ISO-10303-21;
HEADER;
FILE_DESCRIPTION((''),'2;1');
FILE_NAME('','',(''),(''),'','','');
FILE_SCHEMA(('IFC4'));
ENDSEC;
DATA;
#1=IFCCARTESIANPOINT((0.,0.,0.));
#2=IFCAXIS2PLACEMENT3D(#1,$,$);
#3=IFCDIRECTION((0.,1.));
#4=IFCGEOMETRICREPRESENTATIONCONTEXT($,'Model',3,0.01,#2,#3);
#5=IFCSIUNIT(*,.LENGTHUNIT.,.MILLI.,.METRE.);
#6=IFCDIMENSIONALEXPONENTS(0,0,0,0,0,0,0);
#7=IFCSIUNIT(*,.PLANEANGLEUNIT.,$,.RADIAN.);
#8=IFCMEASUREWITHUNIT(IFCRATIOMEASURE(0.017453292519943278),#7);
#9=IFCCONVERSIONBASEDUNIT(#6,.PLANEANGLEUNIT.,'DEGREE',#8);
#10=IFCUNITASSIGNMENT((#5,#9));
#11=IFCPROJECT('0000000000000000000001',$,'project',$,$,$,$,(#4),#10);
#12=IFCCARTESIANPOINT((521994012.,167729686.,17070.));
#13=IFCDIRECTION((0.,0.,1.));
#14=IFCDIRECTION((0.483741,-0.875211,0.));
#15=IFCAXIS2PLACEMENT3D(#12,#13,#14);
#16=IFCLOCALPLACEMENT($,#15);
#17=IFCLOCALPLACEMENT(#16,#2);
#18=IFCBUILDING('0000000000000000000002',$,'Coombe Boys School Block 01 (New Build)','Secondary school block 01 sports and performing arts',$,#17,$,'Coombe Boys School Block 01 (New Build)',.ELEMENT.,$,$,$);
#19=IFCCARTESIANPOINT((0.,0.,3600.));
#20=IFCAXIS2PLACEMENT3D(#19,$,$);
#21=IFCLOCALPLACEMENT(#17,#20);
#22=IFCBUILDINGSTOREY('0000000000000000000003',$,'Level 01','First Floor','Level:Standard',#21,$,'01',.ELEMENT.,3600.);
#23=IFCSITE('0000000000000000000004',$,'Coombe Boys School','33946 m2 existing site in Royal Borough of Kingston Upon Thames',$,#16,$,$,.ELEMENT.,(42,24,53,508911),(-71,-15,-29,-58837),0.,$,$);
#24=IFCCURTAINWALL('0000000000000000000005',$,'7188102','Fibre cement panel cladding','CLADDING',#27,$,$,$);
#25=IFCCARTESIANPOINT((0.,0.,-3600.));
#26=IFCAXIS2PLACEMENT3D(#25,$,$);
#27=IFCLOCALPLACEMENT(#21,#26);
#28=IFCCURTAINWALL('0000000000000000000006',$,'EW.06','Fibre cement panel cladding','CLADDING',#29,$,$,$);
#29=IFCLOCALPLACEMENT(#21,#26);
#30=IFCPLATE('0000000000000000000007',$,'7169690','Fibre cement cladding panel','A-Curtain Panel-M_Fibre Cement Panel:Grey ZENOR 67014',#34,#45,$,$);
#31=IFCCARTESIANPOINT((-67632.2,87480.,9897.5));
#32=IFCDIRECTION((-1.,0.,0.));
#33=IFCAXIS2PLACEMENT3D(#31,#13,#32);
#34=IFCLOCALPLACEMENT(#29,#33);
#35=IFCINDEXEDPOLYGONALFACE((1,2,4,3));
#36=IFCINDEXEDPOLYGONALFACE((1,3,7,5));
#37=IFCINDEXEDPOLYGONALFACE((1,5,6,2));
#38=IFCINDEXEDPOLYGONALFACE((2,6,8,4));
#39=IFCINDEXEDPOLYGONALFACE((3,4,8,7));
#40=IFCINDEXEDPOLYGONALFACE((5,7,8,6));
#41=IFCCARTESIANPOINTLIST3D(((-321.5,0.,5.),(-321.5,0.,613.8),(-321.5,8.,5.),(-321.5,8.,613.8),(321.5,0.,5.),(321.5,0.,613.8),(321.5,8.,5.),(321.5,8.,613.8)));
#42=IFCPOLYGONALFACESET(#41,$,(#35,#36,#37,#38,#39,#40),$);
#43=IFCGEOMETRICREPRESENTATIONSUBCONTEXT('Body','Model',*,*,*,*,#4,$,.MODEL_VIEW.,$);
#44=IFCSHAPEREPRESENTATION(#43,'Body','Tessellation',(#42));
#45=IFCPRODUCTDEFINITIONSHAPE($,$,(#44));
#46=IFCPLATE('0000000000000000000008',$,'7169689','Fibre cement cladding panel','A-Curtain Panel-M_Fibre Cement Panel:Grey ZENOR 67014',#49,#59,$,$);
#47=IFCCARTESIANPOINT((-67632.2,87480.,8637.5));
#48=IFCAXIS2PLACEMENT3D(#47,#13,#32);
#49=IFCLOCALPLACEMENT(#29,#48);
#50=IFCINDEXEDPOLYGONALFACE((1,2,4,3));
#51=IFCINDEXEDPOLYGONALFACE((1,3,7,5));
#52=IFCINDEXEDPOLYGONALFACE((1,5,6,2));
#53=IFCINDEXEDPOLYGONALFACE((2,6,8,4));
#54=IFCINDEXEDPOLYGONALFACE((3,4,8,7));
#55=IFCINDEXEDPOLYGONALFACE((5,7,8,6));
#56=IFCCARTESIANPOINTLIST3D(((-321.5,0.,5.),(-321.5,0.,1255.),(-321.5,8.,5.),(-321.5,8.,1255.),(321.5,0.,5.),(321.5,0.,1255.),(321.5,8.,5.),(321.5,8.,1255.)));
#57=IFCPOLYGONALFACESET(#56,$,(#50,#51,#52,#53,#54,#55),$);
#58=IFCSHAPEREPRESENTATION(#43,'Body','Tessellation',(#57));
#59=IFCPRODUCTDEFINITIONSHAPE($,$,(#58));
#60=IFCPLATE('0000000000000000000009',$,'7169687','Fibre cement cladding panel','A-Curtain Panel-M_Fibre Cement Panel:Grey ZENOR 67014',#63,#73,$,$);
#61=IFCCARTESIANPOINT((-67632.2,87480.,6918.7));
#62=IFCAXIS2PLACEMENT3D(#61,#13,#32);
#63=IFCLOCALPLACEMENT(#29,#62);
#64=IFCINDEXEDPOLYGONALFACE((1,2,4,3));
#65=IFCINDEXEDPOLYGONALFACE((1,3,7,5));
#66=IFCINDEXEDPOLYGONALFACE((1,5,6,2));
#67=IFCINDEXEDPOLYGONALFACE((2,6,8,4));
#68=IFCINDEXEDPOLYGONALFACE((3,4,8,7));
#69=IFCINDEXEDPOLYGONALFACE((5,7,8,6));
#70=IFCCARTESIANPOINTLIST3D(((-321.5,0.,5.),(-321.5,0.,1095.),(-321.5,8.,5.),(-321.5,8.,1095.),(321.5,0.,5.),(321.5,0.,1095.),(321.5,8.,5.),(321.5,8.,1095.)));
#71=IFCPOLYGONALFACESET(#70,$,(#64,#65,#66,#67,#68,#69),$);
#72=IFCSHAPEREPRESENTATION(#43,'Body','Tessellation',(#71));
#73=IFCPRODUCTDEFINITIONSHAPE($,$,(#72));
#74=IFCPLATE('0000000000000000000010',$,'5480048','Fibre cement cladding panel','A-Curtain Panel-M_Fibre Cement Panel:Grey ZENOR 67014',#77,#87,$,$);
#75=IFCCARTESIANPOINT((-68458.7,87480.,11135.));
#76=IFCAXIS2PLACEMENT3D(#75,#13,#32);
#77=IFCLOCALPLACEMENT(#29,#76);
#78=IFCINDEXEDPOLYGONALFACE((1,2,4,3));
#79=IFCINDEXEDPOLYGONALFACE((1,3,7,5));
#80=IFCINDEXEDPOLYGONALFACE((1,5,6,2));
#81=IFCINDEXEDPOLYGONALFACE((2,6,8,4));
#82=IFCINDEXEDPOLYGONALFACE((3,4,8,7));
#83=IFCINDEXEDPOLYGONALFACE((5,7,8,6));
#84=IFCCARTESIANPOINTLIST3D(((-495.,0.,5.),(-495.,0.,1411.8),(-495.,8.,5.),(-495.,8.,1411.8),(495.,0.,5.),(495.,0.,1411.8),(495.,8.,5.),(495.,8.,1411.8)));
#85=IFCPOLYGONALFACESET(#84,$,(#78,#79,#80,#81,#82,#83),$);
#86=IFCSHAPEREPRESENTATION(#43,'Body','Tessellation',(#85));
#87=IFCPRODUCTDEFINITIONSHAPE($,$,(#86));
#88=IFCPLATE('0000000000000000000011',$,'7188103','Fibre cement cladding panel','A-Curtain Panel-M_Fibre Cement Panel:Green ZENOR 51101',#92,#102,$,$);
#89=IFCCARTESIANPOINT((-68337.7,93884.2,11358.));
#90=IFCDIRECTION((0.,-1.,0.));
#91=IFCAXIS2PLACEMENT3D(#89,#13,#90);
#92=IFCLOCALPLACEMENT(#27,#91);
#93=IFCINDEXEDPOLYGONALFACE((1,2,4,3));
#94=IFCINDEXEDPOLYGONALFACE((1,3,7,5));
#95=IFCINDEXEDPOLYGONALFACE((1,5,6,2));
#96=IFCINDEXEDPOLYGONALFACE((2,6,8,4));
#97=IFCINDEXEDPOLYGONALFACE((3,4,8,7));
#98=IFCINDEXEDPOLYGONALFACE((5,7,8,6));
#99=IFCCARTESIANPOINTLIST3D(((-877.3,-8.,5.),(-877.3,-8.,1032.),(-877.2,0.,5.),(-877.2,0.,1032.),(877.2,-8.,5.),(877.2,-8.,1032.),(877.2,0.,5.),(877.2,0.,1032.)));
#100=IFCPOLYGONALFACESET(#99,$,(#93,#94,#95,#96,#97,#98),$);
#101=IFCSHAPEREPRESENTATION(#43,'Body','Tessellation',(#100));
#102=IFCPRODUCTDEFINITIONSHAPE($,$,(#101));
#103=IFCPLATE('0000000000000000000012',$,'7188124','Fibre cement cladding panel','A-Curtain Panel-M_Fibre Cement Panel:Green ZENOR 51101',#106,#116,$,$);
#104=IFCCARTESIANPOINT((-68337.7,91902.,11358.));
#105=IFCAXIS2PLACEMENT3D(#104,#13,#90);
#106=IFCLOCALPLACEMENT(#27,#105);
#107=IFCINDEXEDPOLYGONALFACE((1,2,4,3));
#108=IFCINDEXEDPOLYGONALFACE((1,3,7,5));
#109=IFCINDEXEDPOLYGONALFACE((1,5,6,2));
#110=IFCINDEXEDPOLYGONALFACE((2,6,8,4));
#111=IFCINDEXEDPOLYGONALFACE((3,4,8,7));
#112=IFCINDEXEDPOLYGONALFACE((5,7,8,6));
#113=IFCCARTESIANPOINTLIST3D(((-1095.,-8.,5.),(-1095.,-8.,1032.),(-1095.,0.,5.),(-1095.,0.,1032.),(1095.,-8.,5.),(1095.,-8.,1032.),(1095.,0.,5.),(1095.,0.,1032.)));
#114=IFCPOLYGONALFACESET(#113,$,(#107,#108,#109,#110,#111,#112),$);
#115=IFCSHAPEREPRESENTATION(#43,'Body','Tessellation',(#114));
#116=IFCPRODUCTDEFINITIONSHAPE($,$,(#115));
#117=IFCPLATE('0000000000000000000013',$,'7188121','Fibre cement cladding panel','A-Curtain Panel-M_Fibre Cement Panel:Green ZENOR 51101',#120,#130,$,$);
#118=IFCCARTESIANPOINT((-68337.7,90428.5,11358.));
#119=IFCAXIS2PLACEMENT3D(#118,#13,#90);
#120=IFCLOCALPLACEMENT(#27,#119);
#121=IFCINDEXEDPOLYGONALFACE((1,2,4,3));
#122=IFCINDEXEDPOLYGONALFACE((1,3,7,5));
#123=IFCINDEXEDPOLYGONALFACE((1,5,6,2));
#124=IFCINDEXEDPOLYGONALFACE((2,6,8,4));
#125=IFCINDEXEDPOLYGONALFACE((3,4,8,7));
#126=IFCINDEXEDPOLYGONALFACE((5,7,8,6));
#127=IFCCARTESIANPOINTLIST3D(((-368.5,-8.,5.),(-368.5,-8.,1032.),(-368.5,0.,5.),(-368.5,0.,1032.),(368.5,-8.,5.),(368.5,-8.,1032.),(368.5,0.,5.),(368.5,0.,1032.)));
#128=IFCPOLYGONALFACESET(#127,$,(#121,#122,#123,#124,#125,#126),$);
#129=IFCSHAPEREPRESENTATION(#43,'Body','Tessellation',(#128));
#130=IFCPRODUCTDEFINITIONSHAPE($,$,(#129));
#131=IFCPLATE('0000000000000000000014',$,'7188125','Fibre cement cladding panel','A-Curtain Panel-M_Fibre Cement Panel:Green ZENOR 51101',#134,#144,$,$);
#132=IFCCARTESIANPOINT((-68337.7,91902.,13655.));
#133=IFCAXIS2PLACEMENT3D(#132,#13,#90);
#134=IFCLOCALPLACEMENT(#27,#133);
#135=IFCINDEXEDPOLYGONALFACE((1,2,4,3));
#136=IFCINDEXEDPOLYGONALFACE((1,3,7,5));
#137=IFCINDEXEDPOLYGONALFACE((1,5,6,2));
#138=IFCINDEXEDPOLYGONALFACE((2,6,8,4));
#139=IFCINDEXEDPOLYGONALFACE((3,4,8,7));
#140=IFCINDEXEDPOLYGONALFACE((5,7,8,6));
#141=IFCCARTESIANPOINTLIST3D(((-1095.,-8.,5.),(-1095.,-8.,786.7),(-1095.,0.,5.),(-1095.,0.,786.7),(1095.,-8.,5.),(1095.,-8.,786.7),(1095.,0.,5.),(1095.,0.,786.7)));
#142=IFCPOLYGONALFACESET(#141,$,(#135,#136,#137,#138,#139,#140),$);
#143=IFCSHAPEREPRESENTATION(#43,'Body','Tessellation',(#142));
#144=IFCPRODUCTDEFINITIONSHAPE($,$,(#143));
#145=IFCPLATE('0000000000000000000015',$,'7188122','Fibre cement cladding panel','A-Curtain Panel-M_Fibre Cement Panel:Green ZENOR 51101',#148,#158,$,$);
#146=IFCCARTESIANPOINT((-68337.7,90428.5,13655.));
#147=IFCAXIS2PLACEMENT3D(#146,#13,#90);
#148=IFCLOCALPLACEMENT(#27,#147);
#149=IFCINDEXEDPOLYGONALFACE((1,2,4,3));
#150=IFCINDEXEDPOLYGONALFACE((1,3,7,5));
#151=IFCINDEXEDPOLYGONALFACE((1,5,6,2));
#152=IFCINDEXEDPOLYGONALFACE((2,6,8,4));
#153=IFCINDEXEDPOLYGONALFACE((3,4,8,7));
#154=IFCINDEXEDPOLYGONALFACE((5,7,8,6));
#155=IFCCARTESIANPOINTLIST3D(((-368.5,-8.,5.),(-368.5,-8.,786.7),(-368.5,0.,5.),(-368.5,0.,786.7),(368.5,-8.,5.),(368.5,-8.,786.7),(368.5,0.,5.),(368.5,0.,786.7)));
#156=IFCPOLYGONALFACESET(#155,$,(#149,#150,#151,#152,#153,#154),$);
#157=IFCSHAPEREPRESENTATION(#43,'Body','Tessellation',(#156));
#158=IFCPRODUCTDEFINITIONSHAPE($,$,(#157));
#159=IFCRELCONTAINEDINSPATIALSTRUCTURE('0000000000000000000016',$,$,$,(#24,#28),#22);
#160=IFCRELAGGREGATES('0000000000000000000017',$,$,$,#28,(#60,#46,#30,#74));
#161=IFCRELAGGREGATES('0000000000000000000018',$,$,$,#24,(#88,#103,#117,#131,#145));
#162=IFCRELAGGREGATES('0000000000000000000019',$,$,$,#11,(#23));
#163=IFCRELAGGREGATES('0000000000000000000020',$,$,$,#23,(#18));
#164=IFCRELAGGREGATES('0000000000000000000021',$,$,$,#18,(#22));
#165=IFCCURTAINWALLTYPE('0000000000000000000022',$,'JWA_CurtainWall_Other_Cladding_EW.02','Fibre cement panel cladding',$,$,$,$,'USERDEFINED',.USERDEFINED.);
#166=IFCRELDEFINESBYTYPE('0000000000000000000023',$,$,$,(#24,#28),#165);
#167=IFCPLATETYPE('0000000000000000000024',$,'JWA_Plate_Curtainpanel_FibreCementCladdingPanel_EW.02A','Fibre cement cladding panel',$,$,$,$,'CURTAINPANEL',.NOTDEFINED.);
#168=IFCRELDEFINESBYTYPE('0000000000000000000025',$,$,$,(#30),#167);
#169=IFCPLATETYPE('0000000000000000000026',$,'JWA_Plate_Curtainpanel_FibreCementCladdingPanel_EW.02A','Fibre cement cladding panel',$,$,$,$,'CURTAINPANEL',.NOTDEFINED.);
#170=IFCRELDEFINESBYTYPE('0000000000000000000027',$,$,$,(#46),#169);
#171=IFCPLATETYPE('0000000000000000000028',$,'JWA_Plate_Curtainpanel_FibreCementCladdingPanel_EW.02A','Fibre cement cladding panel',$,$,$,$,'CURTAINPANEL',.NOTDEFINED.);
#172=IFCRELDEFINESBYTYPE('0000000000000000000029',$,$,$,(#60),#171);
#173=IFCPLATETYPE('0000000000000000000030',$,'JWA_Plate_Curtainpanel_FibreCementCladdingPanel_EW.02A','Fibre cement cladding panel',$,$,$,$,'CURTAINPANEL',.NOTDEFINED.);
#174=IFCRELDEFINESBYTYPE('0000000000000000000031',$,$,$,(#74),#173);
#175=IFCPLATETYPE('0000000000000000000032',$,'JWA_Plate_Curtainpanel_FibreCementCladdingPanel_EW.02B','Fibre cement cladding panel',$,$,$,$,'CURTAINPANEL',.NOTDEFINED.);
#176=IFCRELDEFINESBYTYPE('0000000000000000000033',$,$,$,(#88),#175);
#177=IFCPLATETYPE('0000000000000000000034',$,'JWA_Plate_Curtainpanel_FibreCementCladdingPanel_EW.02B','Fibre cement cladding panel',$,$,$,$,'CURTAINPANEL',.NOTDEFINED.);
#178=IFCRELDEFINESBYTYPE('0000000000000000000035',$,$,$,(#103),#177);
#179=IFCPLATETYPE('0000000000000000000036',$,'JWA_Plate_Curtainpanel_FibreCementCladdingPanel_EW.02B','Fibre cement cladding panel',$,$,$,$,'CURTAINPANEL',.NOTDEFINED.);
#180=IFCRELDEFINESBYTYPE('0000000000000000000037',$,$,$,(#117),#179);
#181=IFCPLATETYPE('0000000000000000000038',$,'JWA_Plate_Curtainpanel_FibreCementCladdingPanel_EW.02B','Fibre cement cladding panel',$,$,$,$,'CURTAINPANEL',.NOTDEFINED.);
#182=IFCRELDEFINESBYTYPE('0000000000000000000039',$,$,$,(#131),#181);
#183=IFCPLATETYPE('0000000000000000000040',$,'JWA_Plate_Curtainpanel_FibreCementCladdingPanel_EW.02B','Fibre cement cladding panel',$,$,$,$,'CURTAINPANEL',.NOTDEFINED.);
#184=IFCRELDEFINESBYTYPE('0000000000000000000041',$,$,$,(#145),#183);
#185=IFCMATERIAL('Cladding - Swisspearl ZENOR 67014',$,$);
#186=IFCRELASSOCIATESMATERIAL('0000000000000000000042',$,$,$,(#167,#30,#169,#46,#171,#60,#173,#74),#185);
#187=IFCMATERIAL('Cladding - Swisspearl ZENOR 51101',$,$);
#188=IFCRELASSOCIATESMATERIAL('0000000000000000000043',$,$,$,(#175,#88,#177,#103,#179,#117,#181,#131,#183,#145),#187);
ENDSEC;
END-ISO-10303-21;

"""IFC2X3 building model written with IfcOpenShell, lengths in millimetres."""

from ifc_helpers import new_model, entity, si_unit, converted_unit, direction, frame, origin, origin_2d_with_axis, place, context, subcontext, project, spatial, rectangle, extrude, source, transform, mapped, material, type_object, type_shapes, element, aggregate, save


model = new_model("IFC2X3")

# Units and contexts
model_context = context("Model", 3, precision=0.01, world=origin(), true_north=direction((0.0, 1.0)))
body_context = subcontext(model_context, "Body", "Model", "MODEL_VIEW")
ifc_project = project(units=[si_unit("LENGTHUNIT", "METRE", prefix="MILLI"), converted_unit("PLANEANGLEUNIT", "DEGREE", entity("IfcRatioMeasure", 0.017453292519943278), si_unit("PLANEANGLEUNIT", "RADIAN"), dimensions=[0, 0, 0, 0, 0, 0, 0])], contexts=[model_context])

# Site, building, storey
site_placement = place(None, frame((521994012.0, 167729686.0, 17070.0), z_axis=(0.0, 0.0, 1.0), x_axis=(0.483741, -0.875211, 0.0)))
site = spatial("IfcSite", under=ifc_project, at=site_placement, Name="Coombe Boys School", Description="33946 m2 existing site in Royal Borough of Kingston Upon Thames", CompositionType="ELEMENT", RefLatitude=(42, 24, 53, 508911), RefLongitude=(-71, -15, -29, -58837), RefElevation=0.0)
building_placement = place(site_placement, origin())
building = spatial("IfcBuilding", under=site, at=building_placement, Name="Coombe Boys School Block 01 (New Build)", Description="Secondary school block 01 sports and performing arts", LongName="Coombe Boys School Block 01 (New Build)", CompositionType="ELEMENT")
storey_placement = place(building_placement, frame((0.0, 0.0, 3600.0)))
storey = spatial("IfcBuildingStorey", under=building, at=storey_placement, Name="Level 01", Description="First Floor", ObjectType="Level:Standard", LongName="01", CompositionType="ELEMENT", Elevation=3600.0)

# Curtain wall
curtain_wall_type = type_object("IfcCurtainWallType", Name="JWA_CurtainWall_Other_Cladding_EW.02", Description="Fibre cement panel cladding", ElementType="USERDEFINED", PredefinedType="USERDEFINED")
ifc_material_1 = material(Name="Cladding - Swisspearl ZENOR 51101")
curtain_wall_1_placement = place(storey_placement, frame((0.0, 0.0, -3600.0)))
curtain_wall_1 = element("IfcCurtainWall", 1, at=curtain_wall_1_placement, inside=storey, type_object=curtain_wall_type, Name="7188102", Description="Fibre cement panel cladding", ObjectType="CLADDING")

# Curtain wall, plates
curtain_wall_2_placement = place(storey_placement, frame((0.0, 0.0, -3600.0)))
curtain_wall_2 = element("IfcCurtainWall", 2, at=curtain_wall_2_placement, inside=storey, type_object=curtain_wall_type, Name="EW.06", Description="Fibre cement panel cladding", ObjectType="CLADDING")
ifc_material_2 = material(Name="Cladding - Swisspearl ZENOR 67014")
plate_type_1 = type_object("IfcPlateType", Name="JWA_Plate_Curtainpanel_FibreCementCladdingPanel_EW.02A", Description="Fibre cement cladding panel", ElementType="CURTAINPANEL", PredefinedType="NOTDEFINED", material=ifc_material_2)
shared_shape_1 = source(origin(), body_context, "Body", "SweptSolid", [
    extrude(rectangle(XDim=8.0, YDim=643.0, at=origin_2d_with_axis()), frame((0.0, 4.0, 5.0), z_axis=(0.0, 0.0, 1.0), x_axis=(0.0, 1.0, 0.0)), (0.0, 0.0, 1.0), 608.8),
])
type_shapes(plate_type_1, [shared_shape_1])
plate_1_placement = place(curtain_wall_2_placement, frame((-67632.2, 87480.0, 9897.5), z_axis=(0.0, 0.0, 1.0), x_axis=(-1.0, 0.0, 0.0)))
plate_1 = element("IfcPlate", 3, at=plate_1_placement, type_object=plate_type_1, material=ifc_material_2, Name="7169690", Description="Fibre cement cladding panel", ObjectType="A-Curtain Panel-M_Fibre Cement Panel:Grey ZENOR 67014", context=body_context, shape_type="MappedRepresentation", body=[
    mapped(shared_shape_1, transform((0.0, 0.0, 0.0), scale=1.0)),
])
plate_type_2 = type_object("IfcPlateType", Name="JWA_Plate_Curtainpanel_FibreCementCladdingPanel_EW.02A", Description="Fibre cement cladding panel", ElementType="CURTAINPANEL", PredefinedType="NOTDEFINED", material=ifc_material_2)
shared_shape_2 = source(origin(), body_context, "Body", "SweptSolid", [
    extrude(rectangle(XDim=8.0, YDim=643.0, at=origin_2d_with_axis()), frame((0.0, 4.0, 5.0), z_axis=(0.0, 0.0, 1.0), x_axis=(0.0, 1.0, 0.0)), (0.0, 0.0, 1.0), 1250.0),
])
type_shapes(plate_type_2, [shared_shape_2])
plate_2_placement = place(curtain_wall_2_placement, frame((-67632.2, 87480.0, 8637.5), z_axis=(0.0, 0.0, 1.0), x_axis=(-1.0, 0.0, 0.0)))
plate_2 = element("IfcPlate", 4, at=plate_2_placement, type_object=plate_type_2, material=ifc_material_2, Name="7169689", Description="Fibre cement cladding panel", ObjectType="A-Curtain Panel-M_Fibre Cement Panel:Grey ZENOR 67014", context=body_context, shape_type="MappedRepresentation", body=[
    mapped(shared_shape_2, transform((0.0, 0.0, 0.0), scale=1.0)),
])
plate_type_3 = type_object("IfcPlateType", Name="JWA_Plate_Curtainpanel_FibreCementCladdingPanel_EW.02A", Description="Fibre cement cladding panel", ElementType="CURTAINPANEL", PredefinedType="NOTDEFINED", material=ifc_material_2)
shared_shape_3 = source(origin(), body_context, "Body", "SweptSolid", [
    extrude(rectangle(XDim=8.0, YDim=643.0, at=origin_2d_with_axis()), frame((0.0, 4.0, 5.0), z_axis=(0.0, 0.0, 1.0), x_axis=(0.0, 1.0, 0.0)), (0.0, 0.0, 1.0), 1090.0),
])
type_shapes(plate_type_3, [shared_shape_3])
plate_3_placement = place(curtain_wall_2_placement, frame((-67632.2, 87480.0, 6918.7), z_axis=(0.0, 0.0, 1.0), x_axis=(-1.0, 0.0, 0.0)))
plate_3 = element("IfcPlate", 5, at=plate_3_placement, type_object=plate_type_3, material=ifc_material_2, Name="7169687", Description="Fibre cement cladding panel", ObjectType="A-Curtain Panel-M_Fibre Cement Panel:Grey ZENOR 67014", context=body_context, shape_type="MappedRepresentation", body=[
    mapped(shared_shape_3, transform((0.0, 0.0, 0.0), scale=1.0)),
])
plate_type_4 = type_object("IfcPlateType", Name="JWA_Plate_Curtainpanel_FibreCementCladdingPanel_EW.02A", Description="Fibre cement cladding panel", ElementType="CURTAINPANEL", PredefinedType="NOTDEFINED", material=ifc_material_2)
shared_shape_4 = source(origin(), body_context, "Body", "SweptSolid", [
    extrude(rectangle(XDim=8.0, YDim=990.0, at=origin_2d_with_axis()), frame((0.0, 4.0, 5.0), z_axis=(0.0, 0.0, 1.0), x_axis=(0.0, 1.0, 0.0)), (0.0, 0.0, 1.0), 1406.8),
])
type_shapes(plate_type_4, [shared_shape_4])
plate_4_placement = place(curtain_wall_2_placement, frame((-68458.7, 87480.0, 11135.0), z_axis=(0.0, 0.0, 1.0), x_axis=(-1.0, 0.0, 0.0)))
plate_4 = element("IfcPlate", 6, at=plate_4_placement, type_object=plate_type_4, material=ifc_material_2, Name="5480048", Description="Fibre cement cladding panel", ObjectType="A-Curtain Panel-M_Fibre Cement Panel:Grey ZENOR 67014", context=body_context, shape_type="MappedRepresentation", body=[
    mapped(shared_shape_4, transform((0.0, 0.0, 0.0), scale=1.0)),
])
aggregate(curtain_wall_2, [plate_3, plate_2, plate_1, plate_4])

# Plates
plate_type_5 = type_object("IfcPlateType", Name="JWA_Plate_Curtainpanel_FibreCementCladdingPanel_EW.02B", Description="Fibre cement cladding panel", ElementType="CURTAINPANEL", PredefinedType="NOTDEFINED", material=ifc_material_1)
shared_shape_5 = source(origin(), body_context, "Body", "SweptSolid", [
    extrude(rectangle(XDim=1754.5, YDim=8.0, at=origin_2d_with_axis()), frame((0.0, -4.0, 5.0), z_axis=(0.0, 0.0, 1.0), x_axis=(-1.0, 0.0, 0.0)), (0.0, 0.0, 1.0), 1027.0),
])
type_shapes(plate_type_5, [shared_shape_5])
plate_5_placement = place(curtain_wall_1_placement, frame((-68337.7, 93884.2, 11358.0), z_axis=(0.0, 0.0, 1.0), x_axis=(0.0, -1.0, 0.0)))
plate_5 = element("IfcPlate", 7, at=plate_5_placement, type_object=plate_type_5, material=ifc_material_1, Name="7188103", Description="Fibre cement cladding panel", ObjectType="A-Curtain Panel-M_Fibre Cement Panel:Green ZENOR 51101", context=body_context, shape_type="MappedRepresentation", body=[
    mapped(shared_shape_5, transform((0.0, 0.0, 0.0), scale=1.0)),
])
plate_type_6 = type_object("IfcPlateType", Name="JWA_Plate_Curtainpanel_FibreCementCladdingPanel_EW.02B", Description="Fibre cement cladding panel", ElementType="CURTAINPANEL", PredefinedType="NOTDEFINED", material=ifc_material_1)
shared_shape_6 = source(origin(), body_context, "Body", "SweptSolid", [
    extrude(rectangle(XDim=2190.0, YDim=8.0, at=origin_2d_with_axis()), frame((0.0, -4.0, 5.0), z_axis=(0.0, 0.0, 1.0), x_axis=(-1.0, 0.0, 0.0)), (0.0, 0.0, 1.0), 1027.0),
])
type_shapes(plate_type_6, [shared_shape_6])
plate_6_placement = place(curtain_wall_1_placement, frame((-68337.7, 91902.0, 11358.0), z_axis=(0.0, 0.0, 1.0), x_axis=(0.0, -1.0, 0.0)))
plate_6 = element("IfcPlate", 8, at=plate_6_placement, type_object=plate_type_6, material=ifc_material_1, Name="7188124", Description="Fibre cement cladding panel", ObjectType="A-Curtain Panel-M_Fibre Cement Panel:Green ZENOR 51101", context=body_context, shape_type="MappedRepresentation", body=[
    mapped(shared_shape_6, transform((0.0, 0.0, 0.0), scale=1.0)),
])
plate_type_7 = type_object("IfcPlateType", Name="JWA_Plate_Curtainpanel_FibreCementCladdingPanel_EW.02B", Description="Fibre cement cladding panel", ElementType="CURTAINPANEL", PredefinedType="NOTDEFINED", material=ifc_material_1)
shared_shape_7 = source(origin(), body_context, "Body", "SweptSolid", [
    extrude(rectangle(XDim=737.0, YDim=8.0, at=origin_2d_with_axis()), frame((0.0, -4.0, 5.0), z_axis=(0.0, 0.0, 1.0), x_axis=(-1.0, 0.0, 0.0)), (0.0, 0.0, 1.0), 1027.0),
])
type_shapes(plate_type_7, [shared_shape_7])
plate_7_placement = place(curtain_wall_1_placement, frame((-68337.7, 90428.5, 11358.0), z_axis=(0.0, 0.0, 1.0), x_axis=(0.0, -1.0, 0.0)))
plate_7 = element("IfcPlate", 9, at=plate_7_placement, type_object=plate_type_7, material=ifc_material_1, Name="7188121", Description="Fibre cement cladding panel", ObjectType="A-Curtain Panel-M_Fibre Cement Panel:Green ZENOR 51101", context=body_context, shape_type="MappedRepresentation", body=[
    mapped(shared_shape_7, transform((0.0, 0.0, 0.0), scale=1.0)),
])
plate_type_8 = type_object("IfcPlateType", Name="JWA_Plate_Curtainpanel_FibreCementCladdingPanel_EW.02B", Description="Fibre cement cladding panel", ElementType="CURTAINPANEL", PredefinedType="NOTDEFINED", material=ifc_material_1)
shared_shape_8 = source(origin(), body_context, "Body", "SweptSolid", [
    extrude(rectangle(XDim=2190.0, YDim=8.0, at=origin_2d_with_axis()), frame((0.0, -4.0, 5.0), z_axis=(0.0, 0.0, 1.0), x_axis=(-1.0, 0.0, 0.0)), (0.0, 0.0, 1.0), 781.7),
])
type_shapes(plate_type_8, [shared_shape_8])
plate_8_placement = place(curtain_wall_1_placement, frame((-68337.7, 91902.0, 13655.0), z_axis=(0.0, 0.0, 1.0), x_axis=(0.0, -1.0, 0.0)))
plate_8 = element("IfcPlate", 10, at=plate_8_placement, type_object=plate_type_8, material=ifc_material_1, Name="7188125", Description="Fibre cement cladding panel", ObjectType="A-Curtain Panel-M_Fibre Cement Panel:Green ZENOR 51101", context=body_context, shape_type="MappedRepresentation", body=[
    mapped(shared_shape_8, transform((0.0, 0.0, 0.0), scale=1.0)),
])
plate_type_9 = type_object("IfcPlateType", Name="JWA_Plate_Curtainpanel_FibreCementCladdingPanel_EW.02B", Description="Fibre cement cladding panel", ElementType="CURTAINPANEL", PredefinedType="NOTDEFINED", material=ifc_material_1)
shared_shape_9 = source(origin(), body_context, "Body", "SweptSolid", [
    extrude(rectangle(XDim=737.0, YDim=8.0, at=origin_2d_with_axis()), frame((0.0, -4.0, 5.0), z_axis=(0.0, 0.0, 1.0), x_axis=(-1.0, 0.0, 0.0)), (0.0, 0.0, 1.0), 781.7),
])
type_shapes(plate_type_9, [shared_shape_9])
plate_9_placement = place(curtain_wall_1_placement, frame((-68337.7, 90428.5, 13655.0), z_axis=(0.0, 0.0, 1.0), x_axis=(0.0, -1.0, 0.0)))
plate_9 = element("IfcPlate", 11, at=plate_9_placement, type_object=plate_type_9, material=ifc_material_1, Name="7188122", Description="Fibre cement cladding panel", ObjectType="A-Curtain Panel-M_Fibre Cement Panel:Green ZENOR 51101", context=body_context, shape_type="MappedRepresentation", body=[
    mapped(shared_shape_9, transform((0.0, 0.0, 0.0), scale=1.0)),
])
aggregate(curtain_wall_1, [plate_5, plate_6, plate_7, plate_8, plate_9])

save(model, "model.ifc")
